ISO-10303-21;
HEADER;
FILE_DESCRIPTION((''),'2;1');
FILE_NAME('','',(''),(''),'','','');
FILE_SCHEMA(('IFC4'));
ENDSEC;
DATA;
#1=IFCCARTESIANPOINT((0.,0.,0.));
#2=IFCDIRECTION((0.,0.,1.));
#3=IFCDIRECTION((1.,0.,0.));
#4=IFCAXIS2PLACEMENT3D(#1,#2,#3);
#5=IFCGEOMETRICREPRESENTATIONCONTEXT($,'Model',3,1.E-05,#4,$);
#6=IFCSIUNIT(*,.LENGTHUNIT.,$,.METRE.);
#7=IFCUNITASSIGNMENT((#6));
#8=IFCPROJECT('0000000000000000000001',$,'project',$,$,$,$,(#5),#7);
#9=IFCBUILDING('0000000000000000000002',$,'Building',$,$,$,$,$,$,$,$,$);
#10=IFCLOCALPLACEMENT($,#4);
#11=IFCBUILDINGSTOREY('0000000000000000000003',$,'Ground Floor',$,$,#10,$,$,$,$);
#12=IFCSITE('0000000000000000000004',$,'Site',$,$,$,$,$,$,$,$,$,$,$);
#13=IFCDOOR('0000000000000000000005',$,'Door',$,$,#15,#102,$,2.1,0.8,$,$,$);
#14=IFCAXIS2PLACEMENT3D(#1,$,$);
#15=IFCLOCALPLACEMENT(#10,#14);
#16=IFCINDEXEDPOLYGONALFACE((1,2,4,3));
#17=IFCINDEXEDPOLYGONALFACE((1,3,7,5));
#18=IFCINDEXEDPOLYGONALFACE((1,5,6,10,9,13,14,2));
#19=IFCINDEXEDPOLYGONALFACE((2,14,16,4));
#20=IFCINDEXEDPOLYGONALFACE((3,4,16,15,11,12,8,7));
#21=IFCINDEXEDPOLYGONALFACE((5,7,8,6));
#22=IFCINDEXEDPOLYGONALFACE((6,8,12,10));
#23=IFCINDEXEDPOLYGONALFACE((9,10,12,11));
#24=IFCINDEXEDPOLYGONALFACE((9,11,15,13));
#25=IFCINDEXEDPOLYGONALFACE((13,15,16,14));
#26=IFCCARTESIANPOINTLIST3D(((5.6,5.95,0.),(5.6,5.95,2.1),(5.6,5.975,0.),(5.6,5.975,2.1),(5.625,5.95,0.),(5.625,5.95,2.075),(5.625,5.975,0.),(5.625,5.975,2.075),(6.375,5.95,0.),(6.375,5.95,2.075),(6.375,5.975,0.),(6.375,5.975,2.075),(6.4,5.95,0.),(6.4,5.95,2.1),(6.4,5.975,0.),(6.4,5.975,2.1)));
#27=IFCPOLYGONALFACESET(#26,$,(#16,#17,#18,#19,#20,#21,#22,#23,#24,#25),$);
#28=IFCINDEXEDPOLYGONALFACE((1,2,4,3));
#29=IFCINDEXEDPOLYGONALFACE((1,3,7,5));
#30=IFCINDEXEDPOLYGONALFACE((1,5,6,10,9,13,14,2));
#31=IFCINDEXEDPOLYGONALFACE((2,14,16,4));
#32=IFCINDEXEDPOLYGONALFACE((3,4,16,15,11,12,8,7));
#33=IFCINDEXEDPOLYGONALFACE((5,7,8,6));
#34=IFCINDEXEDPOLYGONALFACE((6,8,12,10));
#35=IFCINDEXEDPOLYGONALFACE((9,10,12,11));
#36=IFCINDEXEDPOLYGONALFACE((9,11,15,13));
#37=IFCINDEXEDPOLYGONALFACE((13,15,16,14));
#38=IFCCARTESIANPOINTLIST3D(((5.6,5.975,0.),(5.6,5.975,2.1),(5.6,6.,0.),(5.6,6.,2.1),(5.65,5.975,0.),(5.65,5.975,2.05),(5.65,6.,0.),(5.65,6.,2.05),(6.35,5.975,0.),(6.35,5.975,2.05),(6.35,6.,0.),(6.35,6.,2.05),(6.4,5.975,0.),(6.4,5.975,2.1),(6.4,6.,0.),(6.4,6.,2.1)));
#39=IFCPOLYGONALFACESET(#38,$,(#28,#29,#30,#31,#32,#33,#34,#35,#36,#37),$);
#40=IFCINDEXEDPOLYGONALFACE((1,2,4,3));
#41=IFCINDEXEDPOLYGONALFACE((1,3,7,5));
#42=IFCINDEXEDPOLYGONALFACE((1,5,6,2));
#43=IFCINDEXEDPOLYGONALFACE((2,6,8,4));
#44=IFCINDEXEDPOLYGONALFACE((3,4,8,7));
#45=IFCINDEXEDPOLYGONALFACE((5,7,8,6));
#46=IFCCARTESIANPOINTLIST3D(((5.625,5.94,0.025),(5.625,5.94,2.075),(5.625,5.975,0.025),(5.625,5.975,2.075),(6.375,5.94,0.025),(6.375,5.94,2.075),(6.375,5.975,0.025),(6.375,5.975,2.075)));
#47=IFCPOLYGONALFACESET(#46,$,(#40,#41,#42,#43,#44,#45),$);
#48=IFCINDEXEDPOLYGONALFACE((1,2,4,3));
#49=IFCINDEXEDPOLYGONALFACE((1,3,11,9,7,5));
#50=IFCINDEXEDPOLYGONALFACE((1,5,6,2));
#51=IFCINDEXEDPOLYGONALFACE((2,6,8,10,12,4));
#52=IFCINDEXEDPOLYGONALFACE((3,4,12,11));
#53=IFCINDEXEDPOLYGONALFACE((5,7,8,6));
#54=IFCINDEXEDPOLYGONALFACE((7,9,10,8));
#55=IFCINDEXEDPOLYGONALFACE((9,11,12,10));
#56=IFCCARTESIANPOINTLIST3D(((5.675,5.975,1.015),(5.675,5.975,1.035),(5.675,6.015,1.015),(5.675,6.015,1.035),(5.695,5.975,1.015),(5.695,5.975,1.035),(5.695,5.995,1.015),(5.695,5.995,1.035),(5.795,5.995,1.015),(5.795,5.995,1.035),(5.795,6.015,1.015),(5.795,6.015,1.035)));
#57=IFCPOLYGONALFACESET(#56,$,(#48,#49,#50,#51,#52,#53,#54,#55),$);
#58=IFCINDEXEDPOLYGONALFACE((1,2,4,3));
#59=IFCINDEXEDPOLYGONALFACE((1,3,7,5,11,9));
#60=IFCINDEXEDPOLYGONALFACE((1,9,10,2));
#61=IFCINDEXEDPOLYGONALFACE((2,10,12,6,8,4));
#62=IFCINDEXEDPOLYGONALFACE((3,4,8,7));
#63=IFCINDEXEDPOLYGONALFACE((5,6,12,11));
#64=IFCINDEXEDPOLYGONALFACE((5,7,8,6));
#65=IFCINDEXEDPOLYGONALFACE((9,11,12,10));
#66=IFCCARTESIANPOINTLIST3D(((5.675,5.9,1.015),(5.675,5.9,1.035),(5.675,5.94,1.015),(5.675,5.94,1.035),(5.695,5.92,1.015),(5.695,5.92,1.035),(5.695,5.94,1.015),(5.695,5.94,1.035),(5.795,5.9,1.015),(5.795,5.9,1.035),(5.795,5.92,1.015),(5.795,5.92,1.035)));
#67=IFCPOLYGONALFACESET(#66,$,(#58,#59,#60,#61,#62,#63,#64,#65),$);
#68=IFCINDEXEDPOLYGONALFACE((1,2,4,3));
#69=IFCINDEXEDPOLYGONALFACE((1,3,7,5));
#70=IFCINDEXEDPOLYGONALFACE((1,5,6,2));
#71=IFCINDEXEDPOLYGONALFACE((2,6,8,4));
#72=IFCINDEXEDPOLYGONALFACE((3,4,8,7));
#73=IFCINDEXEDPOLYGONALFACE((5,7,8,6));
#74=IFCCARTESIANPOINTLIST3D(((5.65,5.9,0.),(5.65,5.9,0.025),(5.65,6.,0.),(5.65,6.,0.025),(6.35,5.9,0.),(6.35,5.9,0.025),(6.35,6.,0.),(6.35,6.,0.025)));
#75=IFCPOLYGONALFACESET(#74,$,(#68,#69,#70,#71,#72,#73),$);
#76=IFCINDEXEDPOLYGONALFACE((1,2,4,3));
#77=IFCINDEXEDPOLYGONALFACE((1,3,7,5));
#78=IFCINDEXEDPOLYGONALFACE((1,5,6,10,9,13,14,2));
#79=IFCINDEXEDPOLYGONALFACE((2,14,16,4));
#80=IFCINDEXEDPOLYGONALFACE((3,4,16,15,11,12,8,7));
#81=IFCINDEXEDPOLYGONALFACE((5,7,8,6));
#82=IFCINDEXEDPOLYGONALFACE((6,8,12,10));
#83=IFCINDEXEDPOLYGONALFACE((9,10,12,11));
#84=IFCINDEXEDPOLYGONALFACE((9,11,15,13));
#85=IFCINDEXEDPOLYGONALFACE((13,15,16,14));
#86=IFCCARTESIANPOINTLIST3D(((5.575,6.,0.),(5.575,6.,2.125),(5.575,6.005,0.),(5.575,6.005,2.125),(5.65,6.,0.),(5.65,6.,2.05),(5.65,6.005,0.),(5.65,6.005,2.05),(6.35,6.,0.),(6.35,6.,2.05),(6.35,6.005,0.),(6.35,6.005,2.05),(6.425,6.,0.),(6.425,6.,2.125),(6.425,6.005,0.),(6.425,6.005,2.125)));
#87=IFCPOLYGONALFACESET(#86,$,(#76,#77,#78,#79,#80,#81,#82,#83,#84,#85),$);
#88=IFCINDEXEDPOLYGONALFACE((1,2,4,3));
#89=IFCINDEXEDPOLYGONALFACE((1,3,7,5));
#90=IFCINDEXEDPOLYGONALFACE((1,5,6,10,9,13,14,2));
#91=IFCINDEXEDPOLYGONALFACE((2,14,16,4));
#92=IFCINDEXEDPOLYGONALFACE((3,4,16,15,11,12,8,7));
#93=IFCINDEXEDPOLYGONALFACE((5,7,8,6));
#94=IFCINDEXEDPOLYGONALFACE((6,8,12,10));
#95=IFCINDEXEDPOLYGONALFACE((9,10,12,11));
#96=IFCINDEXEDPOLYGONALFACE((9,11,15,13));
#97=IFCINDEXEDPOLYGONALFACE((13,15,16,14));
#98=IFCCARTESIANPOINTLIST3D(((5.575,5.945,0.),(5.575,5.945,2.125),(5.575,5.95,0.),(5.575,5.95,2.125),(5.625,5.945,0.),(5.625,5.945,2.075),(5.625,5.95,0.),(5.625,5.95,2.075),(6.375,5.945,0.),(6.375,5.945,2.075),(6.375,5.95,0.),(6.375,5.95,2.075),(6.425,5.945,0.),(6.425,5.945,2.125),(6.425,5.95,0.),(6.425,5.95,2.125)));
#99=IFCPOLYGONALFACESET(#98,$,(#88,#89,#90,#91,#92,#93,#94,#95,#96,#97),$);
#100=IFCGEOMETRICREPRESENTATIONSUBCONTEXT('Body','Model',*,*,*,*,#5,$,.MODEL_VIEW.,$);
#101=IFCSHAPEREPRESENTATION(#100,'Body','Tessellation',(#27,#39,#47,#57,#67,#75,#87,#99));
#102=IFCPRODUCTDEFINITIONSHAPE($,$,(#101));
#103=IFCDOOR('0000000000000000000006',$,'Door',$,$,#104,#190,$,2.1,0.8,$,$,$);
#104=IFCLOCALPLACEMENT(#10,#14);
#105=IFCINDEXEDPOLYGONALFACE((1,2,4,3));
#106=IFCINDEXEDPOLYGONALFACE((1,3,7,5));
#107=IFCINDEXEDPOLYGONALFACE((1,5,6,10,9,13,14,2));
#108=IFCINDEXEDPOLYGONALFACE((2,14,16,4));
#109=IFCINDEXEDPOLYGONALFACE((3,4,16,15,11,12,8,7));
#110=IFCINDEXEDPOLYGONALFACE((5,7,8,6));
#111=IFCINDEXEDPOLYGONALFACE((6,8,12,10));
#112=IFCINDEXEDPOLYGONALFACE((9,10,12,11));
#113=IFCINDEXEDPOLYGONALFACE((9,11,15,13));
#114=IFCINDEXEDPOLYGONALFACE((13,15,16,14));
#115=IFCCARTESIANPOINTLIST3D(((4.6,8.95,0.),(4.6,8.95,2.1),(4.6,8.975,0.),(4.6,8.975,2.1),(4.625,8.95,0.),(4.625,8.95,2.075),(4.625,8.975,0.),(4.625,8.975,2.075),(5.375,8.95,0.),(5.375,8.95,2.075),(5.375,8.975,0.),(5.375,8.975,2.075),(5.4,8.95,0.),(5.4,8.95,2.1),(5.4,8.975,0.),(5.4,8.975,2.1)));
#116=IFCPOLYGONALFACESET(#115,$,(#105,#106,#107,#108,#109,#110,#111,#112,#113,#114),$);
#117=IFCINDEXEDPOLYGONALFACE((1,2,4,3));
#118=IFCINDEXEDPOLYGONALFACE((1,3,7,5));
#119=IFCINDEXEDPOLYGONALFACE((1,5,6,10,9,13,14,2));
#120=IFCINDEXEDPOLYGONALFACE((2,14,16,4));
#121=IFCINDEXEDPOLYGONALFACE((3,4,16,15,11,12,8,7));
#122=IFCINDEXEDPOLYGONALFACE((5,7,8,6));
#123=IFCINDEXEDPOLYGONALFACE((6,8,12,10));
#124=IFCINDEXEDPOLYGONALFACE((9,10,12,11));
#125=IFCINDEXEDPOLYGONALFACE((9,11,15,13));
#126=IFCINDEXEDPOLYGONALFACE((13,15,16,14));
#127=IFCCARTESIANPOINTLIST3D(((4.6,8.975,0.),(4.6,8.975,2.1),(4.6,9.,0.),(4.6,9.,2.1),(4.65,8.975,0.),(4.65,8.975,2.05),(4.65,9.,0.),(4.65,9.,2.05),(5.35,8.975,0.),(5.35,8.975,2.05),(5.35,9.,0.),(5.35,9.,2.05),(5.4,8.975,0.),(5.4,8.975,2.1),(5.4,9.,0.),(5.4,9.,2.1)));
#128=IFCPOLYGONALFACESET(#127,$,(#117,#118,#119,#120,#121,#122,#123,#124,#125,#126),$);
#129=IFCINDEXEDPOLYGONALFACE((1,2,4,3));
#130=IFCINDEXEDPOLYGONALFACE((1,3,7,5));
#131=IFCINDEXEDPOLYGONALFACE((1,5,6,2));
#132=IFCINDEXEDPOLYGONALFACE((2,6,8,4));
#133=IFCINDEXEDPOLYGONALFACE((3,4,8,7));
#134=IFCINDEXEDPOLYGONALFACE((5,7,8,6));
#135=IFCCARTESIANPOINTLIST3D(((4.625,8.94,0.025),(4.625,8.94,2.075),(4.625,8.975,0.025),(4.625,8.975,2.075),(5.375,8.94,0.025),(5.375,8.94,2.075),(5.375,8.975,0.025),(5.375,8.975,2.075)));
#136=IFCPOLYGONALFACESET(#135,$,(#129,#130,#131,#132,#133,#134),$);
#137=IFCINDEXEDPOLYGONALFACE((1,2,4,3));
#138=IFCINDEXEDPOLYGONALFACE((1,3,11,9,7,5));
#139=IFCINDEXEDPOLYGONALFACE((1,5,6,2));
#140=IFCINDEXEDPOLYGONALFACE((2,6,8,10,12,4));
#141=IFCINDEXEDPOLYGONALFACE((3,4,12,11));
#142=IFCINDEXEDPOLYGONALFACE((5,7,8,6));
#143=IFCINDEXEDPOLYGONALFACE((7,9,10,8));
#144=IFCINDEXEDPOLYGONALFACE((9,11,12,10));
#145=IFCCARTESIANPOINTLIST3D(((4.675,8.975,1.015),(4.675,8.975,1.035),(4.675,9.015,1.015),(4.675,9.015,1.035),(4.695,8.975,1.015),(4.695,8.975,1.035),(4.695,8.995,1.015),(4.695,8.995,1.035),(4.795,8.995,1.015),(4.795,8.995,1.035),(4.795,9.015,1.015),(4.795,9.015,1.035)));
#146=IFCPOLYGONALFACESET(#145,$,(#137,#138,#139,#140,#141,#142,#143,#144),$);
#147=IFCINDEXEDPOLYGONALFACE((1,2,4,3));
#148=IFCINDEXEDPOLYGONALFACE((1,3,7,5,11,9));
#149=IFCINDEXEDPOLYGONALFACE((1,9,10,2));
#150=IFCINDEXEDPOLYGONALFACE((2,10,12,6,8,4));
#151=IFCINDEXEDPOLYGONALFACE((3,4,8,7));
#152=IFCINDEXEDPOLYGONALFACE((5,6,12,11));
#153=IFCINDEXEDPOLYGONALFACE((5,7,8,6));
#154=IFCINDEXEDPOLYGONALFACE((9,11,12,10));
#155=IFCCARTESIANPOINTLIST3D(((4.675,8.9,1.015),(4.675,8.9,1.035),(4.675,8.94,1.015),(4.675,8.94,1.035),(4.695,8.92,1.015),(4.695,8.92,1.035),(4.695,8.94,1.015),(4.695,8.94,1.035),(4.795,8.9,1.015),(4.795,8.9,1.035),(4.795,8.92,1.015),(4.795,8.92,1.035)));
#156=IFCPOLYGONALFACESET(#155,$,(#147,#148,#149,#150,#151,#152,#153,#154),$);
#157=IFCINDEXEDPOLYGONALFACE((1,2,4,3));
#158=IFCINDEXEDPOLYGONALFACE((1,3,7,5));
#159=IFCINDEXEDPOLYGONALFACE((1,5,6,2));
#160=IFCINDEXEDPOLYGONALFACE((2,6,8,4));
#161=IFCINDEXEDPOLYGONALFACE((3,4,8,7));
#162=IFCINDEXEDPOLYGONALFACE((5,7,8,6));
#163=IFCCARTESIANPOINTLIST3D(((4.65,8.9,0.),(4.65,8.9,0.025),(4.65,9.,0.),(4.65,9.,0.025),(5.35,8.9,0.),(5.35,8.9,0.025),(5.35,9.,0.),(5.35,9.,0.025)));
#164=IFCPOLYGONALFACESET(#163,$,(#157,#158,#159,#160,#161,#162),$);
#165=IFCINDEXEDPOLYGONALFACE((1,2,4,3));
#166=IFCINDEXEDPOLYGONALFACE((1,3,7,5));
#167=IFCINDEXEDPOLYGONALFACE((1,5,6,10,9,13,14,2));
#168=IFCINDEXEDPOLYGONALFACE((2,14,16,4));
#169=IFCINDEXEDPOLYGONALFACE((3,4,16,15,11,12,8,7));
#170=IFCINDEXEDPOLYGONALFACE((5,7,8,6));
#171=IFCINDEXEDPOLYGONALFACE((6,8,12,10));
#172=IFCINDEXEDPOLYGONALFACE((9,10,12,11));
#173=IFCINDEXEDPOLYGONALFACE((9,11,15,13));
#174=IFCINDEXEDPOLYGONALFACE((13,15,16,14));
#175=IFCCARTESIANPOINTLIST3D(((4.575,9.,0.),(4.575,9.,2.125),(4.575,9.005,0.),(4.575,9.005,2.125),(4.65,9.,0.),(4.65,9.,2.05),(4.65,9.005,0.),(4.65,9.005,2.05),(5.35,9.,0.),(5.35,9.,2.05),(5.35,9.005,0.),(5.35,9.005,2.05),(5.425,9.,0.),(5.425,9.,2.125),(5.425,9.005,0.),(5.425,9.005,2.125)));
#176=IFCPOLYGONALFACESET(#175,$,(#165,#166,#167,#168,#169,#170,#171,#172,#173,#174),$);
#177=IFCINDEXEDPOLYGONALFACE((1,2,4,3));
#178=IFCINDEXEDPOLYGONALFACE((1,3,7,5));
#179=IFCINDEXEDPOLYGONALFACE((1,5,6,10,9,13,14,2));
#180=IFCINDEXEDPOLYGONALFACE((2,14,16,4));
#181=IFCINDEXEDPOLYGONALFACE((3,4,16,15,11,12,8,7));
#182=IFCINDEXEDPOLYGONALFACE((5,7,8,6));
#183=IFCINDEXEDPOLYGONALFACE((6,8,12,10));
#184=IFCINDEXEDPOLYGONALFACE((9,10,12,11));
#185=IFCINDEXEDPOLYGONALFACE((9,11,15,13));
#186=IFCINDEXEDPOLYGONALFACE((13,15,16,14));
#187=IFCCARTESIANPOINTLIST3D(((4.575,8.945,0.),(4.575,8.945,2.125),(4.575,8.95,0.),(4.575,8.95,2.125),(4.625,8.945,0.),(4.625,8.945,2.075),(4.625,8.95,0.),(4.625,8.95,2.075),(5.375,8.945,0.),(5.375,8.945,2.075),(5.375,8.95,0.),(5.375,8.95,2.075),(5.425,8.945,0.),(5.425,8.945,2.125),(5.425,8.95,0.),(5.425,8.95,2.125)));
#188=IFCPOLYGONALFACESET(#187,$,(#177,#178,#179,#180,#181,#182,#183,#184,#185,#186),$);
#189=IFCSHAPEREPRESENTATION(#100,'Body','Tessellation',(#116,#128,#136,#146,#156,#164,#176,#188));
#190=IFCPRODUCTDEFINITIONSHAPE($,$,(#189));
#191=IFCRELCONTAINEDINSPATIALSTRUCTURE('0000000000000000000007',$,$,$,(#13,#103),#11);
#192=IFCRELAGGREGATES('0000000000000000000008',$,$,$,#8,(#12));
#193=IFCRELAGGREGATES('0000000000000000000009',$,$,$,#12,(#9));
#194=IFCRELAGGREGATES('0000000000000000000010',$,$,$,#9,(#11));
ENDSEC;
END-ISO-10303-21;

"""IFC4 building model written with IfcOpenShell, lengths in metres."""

from ifc_helpers import new_model, si_unit, frame, origin_with_axes, place, context, subcontext, project, spatial, line, indexed_curve, outline, extrude, element, save


model = new_model("IFC4")

# Units and contexts
model_context = context("Model", 3, precision=1e-05, world=origin_with_axes())
body_context = subcontext(model_context, "Body", "Model", "MODEL_VIEW")
ifc_project = project(units=[si_unit("LENGTHUNIT", "METRE")], contexts=[model_context])

# Site, building, storey
site = spatial("IfcSite", under=ifc_project, Name="Site")
building = spatial("IfcBuilding", under=site, Name="Building")
storey_placement = place(None, origin_with_axes())
storey = spatial("IfcBuildingStorey", under=building, at=storey_placement, Name="Ground Floor")

# Doors
door_1_placement = place(storey_placement, frame((6.4, 6.0, 0.0), z_axis=(0.0, 0.0, 1.0), x_axis=(-1.0, 0.0, 0.0)))
element("IfcDoor", 1, at=door_1_placement, inside=storey, Name="Door", OverallHeight=2.1, OverallWidth=0.8, context=body_context, shape_type="SweptSolid", body=[
    extrude(outline(indexed_curve([(0.0, 0.0), (0.0, 2.1), (0.8, 2.1), (0.8, 0.0), (0.775, 0.0), (0.775, 2.075), (0.025, 2.075), (0.025, 0.0)], segments=[line(1, 2, 3, 4, 5, 6, 7, 8, 1)])), frame((0.0, 0.025, 0.0), z_axis=(0.0, -1.0, 0.0), x_axis=(1.0, 0.0, 0.0)), (0.0, 0.0, -1.0), 0.025),
    extrude(outline(indexed_curve([(0.0, 0.0), (0.0, 2.1), (0.8, 2.1), (0.8, 0.0), (0.75, 0.0), (0.75, 2.05), (0.05, 2.05), (0.05, 0.0)], segments=[line(1, 2, 3, 4, 5, 6, 7, 8, 1)])), frame((0.0, 0.0, 0.0), z_axis=(0.0, -1.0, 0.0), x_axis=(1.0, 0.0, 0.0)), (0.0, 0.0, -1.0), 0.025),
    extrude(outline(indexed_curve([(0.0, 0.0), (0.75, 0.0), (0.75, 0.035), (0.0, 0.035)], segments=[line(1, 2, 3, 4, 1)])), frame((0.025, 0.025, 0.025), z_axis=(0.0, 0.0, 1.0), x_axis=(1.0, 0.0, 0.0)), (0.0, 0.0, 1.0), 2.05),
    extrude(outline(indexed_curve([(0.0, 0.0), (0.0, -0.04), (-0.12, -0.04), (-0.12, -0.02), (-0.02, -0.02), (-0.02, 0.0)], segments=[line(1, 2, 3, 4, 5, 6, 1)])), frame((0.725, 0.025, 1.015), z_axis=(0.0, 0.0, 1.0), x_axis=(1.0, 0.0, 0.0)), (0.0, 0.0, 1.0), 0.02),
    extrude(outline(indexed_curve([(0.0, 0.0), (0.0, 0.04), (-0.12, 0.04), (-0.12, 0.02), (-0.02, 0.02), (-0.02, 0.0)], segments=[line(1, 2, 3, 4, 5, 6, 1)])), frame((0.725, 0.06, 1.015), z_axis=(0.0, 0.0, 1.0), x_axis=(1.0, 0.0, 0.0)), (0.0, 0.0, 1.0), 0.02),
    extrude(outline(indexed_curve([(0.0, 0.0), (0.7, 0.0), (0.7, 0.1), (0.0, 0.1)], segments=[line(1, 2, 3, 4, 1)])), frame((0.05, 0.0, 0.0), z_axis=(0.0, 0.0, 1.0), x_axis=(1.0, 0.0, 0.0)), (0.0, 0.0, 1.0), 0.025),
    extrude(outline(indexed_curve([(0.0, 0.0), (0.0, 2.125), (0.85, 2.125), (0.85, 0.0), (0.775, 0.0), (0.775, 2.05), (0.075, 2.05), (0.075, 0.0)], segments=[line(1, 2, 3, 4, 5, 6, 7, 8, 1)])), frame((-0.025, -0.005, 0.0), z_axis=(0.0, -1.0, 0.0), x_axis=(1.0, 0.0, 0.0)), (0.0, 0.0, -1.0), 0.005),
    extrude(outline(indexed_curve([(0.0, 0.0), (0.0, 2.125), (0.85, 2.125), (0.85, 0.0), (0.8, 0.0), (0.8, 2.075), (0.05, 2.075), (0.05, 0.0)], segments=[line(1, 2, 3, 4, 5, 6, 7, 8, 1)])), frame((-0.025, 0.05, 0.0), z_axis=(0.0, -1.0, 0.0), x_axis=(1.0, 0.0, 0.0)), (0.0, 0.0, -1.0), 0.005),
])
door_2_placement = place(storey_placement, frame((5.4, 9.0, 0.0), z_axis=(0.0, 0.0, 1.0), x_axis=(-1.0, 0.0, 0.0)))
element("IfcDoor", 2, at=door_2_placement, inside=storey, Name="Door", OverallHeight=2.1, OverallWidth=0.8, context=body_context, shape_type="SweptSolid", body=[
    extrude(outline(indexed_curve([(0.0, 0.0), (0.0, 2.1), (0.8, 2.1), (0.8, 0.0), (0.775, 0.0), (0.775, 2.075), (0.025, 2.075), (0.025, 0.0)], segments=[line(1, 2, 3, 4, 5, 6, 7, 8, 1)])), frame((0.0, 0.025, 0.0), z_axis=(0.0, -1.0, 0.0), x_axis=(1.0, 0.0, 0.0)), (0.0, 0.0, -1.0), 0.025),
    extrude(outline(indexed_curve([(0.0, 0.0), (0.0, 2.1), (0.8, 2.1), (0.8, 0.0), (0.75, 0.0), (0.75, 2.05), (0.05, 2.05), (0.05, 0.0)], segments=[line(1, 2, 3, 4, 5, 6, 7, 8, 1)])), frame((0.0, 0.0, 0.0), z_axis=(0.0, -1.0, 0.0), x_axis=(1.0, 0.0, 0.0)), (0.0, 0.0, -1.0), 0.025),
    extrude(outline(indexed_curve([(0.0, 0.0), (0.75, 0.0), (0.75, 0.035), (0.0, 0.035)], segments=[line(1, 2, 3, 4, 1)])), frame((0.025, 0.025, 0.025), z_axis=(0.0, 0.0, 1.0), x_axis=(1.0, 0.0, 0.0)), (0.0, 0.0, 1.0), 2.05),
    extrude(outline(indexed_curve([(0.0, 0.0), (0.0, -0.04), (-0.12, -0.04), (-0.12, -0.02), (-0.02, -0.02), (-0.02, 0.0)], segments=[line(1, 2, 3, 4, 5, 6, 1)])), frame((0.725, 0.025, 1.015), z_axis=(0.0, 0.0, 1.0), x_axis=(1.0, 0.0, 0.0)), (0.0, 0.0, 1.0), 0.02),
    extrude(outline(indexed_curve([(0.0, 0.0), (0.0, 0.04), (-0.12, 0.04), (-0.12, 0.02), (-0.02, 0.02), (-0.02, 0.0)], segments=[line(1, 2, 3, 4, 5, 6, 1)])), frame((0.725, 0.06, 1.015), z_axis=(0.0, 0.0, 1.0), x_axis=(1.0, 0.0, 0.0)), (0.0, 0.0, 1.0), 0.02),
    extrude(outline(indexed_curve([(0.0, 0.0), (0.7, 0.0), (0.7, 0.1), (0.0, 0.1)], segments=[line(1, 2, 3, 4, 1)])), frame((0.05, 0.0, 0.0), z_axis=(0.0, 0.0, 1.0), x_axis=(1.0, 0.0, 0.0)), (0.0, 0.0, 1.0), 0.025),
    extrude(outline(indexed_curve([(0.0, 0.0), (0.0, 2.125), (0.85, 2.125), (0.85, 0.0), (0.775, 0.0), (0.775, 2.05), (0.075, 2.05), (0.075, 0.0)], segments=[line(1, 2, 3, 4, 5, 6, 7, 8, 1)])), frame((-0.025, -0.005, 0.0), z_axis=(0.0, -1.0, 0.0), x_axis=(1.0, 0.0, 0.0)), (0.0, 0.0, -1.0), 0.005),
    extrude(outline(indexed_curve([(0.0, 0.0), (0.0, 2.125), (0.85, 2.125), (0.85, 0.0), (0.8, 0.0), (0.8, 2.075), (0.05, 2.075), (0.05, 0.0)], segments=[line(1, 2, 3, 4, 5, 6, 7, 8, 1)])), frame((-0.025, 0.05, 0.0), z_axis=(0.0, -1.0, 0.0), x_axis=(1.0, 0.0, 0.0)), (0.0, 0.0, -1.0), 0.005),
])

save(model, "model.ifc")
